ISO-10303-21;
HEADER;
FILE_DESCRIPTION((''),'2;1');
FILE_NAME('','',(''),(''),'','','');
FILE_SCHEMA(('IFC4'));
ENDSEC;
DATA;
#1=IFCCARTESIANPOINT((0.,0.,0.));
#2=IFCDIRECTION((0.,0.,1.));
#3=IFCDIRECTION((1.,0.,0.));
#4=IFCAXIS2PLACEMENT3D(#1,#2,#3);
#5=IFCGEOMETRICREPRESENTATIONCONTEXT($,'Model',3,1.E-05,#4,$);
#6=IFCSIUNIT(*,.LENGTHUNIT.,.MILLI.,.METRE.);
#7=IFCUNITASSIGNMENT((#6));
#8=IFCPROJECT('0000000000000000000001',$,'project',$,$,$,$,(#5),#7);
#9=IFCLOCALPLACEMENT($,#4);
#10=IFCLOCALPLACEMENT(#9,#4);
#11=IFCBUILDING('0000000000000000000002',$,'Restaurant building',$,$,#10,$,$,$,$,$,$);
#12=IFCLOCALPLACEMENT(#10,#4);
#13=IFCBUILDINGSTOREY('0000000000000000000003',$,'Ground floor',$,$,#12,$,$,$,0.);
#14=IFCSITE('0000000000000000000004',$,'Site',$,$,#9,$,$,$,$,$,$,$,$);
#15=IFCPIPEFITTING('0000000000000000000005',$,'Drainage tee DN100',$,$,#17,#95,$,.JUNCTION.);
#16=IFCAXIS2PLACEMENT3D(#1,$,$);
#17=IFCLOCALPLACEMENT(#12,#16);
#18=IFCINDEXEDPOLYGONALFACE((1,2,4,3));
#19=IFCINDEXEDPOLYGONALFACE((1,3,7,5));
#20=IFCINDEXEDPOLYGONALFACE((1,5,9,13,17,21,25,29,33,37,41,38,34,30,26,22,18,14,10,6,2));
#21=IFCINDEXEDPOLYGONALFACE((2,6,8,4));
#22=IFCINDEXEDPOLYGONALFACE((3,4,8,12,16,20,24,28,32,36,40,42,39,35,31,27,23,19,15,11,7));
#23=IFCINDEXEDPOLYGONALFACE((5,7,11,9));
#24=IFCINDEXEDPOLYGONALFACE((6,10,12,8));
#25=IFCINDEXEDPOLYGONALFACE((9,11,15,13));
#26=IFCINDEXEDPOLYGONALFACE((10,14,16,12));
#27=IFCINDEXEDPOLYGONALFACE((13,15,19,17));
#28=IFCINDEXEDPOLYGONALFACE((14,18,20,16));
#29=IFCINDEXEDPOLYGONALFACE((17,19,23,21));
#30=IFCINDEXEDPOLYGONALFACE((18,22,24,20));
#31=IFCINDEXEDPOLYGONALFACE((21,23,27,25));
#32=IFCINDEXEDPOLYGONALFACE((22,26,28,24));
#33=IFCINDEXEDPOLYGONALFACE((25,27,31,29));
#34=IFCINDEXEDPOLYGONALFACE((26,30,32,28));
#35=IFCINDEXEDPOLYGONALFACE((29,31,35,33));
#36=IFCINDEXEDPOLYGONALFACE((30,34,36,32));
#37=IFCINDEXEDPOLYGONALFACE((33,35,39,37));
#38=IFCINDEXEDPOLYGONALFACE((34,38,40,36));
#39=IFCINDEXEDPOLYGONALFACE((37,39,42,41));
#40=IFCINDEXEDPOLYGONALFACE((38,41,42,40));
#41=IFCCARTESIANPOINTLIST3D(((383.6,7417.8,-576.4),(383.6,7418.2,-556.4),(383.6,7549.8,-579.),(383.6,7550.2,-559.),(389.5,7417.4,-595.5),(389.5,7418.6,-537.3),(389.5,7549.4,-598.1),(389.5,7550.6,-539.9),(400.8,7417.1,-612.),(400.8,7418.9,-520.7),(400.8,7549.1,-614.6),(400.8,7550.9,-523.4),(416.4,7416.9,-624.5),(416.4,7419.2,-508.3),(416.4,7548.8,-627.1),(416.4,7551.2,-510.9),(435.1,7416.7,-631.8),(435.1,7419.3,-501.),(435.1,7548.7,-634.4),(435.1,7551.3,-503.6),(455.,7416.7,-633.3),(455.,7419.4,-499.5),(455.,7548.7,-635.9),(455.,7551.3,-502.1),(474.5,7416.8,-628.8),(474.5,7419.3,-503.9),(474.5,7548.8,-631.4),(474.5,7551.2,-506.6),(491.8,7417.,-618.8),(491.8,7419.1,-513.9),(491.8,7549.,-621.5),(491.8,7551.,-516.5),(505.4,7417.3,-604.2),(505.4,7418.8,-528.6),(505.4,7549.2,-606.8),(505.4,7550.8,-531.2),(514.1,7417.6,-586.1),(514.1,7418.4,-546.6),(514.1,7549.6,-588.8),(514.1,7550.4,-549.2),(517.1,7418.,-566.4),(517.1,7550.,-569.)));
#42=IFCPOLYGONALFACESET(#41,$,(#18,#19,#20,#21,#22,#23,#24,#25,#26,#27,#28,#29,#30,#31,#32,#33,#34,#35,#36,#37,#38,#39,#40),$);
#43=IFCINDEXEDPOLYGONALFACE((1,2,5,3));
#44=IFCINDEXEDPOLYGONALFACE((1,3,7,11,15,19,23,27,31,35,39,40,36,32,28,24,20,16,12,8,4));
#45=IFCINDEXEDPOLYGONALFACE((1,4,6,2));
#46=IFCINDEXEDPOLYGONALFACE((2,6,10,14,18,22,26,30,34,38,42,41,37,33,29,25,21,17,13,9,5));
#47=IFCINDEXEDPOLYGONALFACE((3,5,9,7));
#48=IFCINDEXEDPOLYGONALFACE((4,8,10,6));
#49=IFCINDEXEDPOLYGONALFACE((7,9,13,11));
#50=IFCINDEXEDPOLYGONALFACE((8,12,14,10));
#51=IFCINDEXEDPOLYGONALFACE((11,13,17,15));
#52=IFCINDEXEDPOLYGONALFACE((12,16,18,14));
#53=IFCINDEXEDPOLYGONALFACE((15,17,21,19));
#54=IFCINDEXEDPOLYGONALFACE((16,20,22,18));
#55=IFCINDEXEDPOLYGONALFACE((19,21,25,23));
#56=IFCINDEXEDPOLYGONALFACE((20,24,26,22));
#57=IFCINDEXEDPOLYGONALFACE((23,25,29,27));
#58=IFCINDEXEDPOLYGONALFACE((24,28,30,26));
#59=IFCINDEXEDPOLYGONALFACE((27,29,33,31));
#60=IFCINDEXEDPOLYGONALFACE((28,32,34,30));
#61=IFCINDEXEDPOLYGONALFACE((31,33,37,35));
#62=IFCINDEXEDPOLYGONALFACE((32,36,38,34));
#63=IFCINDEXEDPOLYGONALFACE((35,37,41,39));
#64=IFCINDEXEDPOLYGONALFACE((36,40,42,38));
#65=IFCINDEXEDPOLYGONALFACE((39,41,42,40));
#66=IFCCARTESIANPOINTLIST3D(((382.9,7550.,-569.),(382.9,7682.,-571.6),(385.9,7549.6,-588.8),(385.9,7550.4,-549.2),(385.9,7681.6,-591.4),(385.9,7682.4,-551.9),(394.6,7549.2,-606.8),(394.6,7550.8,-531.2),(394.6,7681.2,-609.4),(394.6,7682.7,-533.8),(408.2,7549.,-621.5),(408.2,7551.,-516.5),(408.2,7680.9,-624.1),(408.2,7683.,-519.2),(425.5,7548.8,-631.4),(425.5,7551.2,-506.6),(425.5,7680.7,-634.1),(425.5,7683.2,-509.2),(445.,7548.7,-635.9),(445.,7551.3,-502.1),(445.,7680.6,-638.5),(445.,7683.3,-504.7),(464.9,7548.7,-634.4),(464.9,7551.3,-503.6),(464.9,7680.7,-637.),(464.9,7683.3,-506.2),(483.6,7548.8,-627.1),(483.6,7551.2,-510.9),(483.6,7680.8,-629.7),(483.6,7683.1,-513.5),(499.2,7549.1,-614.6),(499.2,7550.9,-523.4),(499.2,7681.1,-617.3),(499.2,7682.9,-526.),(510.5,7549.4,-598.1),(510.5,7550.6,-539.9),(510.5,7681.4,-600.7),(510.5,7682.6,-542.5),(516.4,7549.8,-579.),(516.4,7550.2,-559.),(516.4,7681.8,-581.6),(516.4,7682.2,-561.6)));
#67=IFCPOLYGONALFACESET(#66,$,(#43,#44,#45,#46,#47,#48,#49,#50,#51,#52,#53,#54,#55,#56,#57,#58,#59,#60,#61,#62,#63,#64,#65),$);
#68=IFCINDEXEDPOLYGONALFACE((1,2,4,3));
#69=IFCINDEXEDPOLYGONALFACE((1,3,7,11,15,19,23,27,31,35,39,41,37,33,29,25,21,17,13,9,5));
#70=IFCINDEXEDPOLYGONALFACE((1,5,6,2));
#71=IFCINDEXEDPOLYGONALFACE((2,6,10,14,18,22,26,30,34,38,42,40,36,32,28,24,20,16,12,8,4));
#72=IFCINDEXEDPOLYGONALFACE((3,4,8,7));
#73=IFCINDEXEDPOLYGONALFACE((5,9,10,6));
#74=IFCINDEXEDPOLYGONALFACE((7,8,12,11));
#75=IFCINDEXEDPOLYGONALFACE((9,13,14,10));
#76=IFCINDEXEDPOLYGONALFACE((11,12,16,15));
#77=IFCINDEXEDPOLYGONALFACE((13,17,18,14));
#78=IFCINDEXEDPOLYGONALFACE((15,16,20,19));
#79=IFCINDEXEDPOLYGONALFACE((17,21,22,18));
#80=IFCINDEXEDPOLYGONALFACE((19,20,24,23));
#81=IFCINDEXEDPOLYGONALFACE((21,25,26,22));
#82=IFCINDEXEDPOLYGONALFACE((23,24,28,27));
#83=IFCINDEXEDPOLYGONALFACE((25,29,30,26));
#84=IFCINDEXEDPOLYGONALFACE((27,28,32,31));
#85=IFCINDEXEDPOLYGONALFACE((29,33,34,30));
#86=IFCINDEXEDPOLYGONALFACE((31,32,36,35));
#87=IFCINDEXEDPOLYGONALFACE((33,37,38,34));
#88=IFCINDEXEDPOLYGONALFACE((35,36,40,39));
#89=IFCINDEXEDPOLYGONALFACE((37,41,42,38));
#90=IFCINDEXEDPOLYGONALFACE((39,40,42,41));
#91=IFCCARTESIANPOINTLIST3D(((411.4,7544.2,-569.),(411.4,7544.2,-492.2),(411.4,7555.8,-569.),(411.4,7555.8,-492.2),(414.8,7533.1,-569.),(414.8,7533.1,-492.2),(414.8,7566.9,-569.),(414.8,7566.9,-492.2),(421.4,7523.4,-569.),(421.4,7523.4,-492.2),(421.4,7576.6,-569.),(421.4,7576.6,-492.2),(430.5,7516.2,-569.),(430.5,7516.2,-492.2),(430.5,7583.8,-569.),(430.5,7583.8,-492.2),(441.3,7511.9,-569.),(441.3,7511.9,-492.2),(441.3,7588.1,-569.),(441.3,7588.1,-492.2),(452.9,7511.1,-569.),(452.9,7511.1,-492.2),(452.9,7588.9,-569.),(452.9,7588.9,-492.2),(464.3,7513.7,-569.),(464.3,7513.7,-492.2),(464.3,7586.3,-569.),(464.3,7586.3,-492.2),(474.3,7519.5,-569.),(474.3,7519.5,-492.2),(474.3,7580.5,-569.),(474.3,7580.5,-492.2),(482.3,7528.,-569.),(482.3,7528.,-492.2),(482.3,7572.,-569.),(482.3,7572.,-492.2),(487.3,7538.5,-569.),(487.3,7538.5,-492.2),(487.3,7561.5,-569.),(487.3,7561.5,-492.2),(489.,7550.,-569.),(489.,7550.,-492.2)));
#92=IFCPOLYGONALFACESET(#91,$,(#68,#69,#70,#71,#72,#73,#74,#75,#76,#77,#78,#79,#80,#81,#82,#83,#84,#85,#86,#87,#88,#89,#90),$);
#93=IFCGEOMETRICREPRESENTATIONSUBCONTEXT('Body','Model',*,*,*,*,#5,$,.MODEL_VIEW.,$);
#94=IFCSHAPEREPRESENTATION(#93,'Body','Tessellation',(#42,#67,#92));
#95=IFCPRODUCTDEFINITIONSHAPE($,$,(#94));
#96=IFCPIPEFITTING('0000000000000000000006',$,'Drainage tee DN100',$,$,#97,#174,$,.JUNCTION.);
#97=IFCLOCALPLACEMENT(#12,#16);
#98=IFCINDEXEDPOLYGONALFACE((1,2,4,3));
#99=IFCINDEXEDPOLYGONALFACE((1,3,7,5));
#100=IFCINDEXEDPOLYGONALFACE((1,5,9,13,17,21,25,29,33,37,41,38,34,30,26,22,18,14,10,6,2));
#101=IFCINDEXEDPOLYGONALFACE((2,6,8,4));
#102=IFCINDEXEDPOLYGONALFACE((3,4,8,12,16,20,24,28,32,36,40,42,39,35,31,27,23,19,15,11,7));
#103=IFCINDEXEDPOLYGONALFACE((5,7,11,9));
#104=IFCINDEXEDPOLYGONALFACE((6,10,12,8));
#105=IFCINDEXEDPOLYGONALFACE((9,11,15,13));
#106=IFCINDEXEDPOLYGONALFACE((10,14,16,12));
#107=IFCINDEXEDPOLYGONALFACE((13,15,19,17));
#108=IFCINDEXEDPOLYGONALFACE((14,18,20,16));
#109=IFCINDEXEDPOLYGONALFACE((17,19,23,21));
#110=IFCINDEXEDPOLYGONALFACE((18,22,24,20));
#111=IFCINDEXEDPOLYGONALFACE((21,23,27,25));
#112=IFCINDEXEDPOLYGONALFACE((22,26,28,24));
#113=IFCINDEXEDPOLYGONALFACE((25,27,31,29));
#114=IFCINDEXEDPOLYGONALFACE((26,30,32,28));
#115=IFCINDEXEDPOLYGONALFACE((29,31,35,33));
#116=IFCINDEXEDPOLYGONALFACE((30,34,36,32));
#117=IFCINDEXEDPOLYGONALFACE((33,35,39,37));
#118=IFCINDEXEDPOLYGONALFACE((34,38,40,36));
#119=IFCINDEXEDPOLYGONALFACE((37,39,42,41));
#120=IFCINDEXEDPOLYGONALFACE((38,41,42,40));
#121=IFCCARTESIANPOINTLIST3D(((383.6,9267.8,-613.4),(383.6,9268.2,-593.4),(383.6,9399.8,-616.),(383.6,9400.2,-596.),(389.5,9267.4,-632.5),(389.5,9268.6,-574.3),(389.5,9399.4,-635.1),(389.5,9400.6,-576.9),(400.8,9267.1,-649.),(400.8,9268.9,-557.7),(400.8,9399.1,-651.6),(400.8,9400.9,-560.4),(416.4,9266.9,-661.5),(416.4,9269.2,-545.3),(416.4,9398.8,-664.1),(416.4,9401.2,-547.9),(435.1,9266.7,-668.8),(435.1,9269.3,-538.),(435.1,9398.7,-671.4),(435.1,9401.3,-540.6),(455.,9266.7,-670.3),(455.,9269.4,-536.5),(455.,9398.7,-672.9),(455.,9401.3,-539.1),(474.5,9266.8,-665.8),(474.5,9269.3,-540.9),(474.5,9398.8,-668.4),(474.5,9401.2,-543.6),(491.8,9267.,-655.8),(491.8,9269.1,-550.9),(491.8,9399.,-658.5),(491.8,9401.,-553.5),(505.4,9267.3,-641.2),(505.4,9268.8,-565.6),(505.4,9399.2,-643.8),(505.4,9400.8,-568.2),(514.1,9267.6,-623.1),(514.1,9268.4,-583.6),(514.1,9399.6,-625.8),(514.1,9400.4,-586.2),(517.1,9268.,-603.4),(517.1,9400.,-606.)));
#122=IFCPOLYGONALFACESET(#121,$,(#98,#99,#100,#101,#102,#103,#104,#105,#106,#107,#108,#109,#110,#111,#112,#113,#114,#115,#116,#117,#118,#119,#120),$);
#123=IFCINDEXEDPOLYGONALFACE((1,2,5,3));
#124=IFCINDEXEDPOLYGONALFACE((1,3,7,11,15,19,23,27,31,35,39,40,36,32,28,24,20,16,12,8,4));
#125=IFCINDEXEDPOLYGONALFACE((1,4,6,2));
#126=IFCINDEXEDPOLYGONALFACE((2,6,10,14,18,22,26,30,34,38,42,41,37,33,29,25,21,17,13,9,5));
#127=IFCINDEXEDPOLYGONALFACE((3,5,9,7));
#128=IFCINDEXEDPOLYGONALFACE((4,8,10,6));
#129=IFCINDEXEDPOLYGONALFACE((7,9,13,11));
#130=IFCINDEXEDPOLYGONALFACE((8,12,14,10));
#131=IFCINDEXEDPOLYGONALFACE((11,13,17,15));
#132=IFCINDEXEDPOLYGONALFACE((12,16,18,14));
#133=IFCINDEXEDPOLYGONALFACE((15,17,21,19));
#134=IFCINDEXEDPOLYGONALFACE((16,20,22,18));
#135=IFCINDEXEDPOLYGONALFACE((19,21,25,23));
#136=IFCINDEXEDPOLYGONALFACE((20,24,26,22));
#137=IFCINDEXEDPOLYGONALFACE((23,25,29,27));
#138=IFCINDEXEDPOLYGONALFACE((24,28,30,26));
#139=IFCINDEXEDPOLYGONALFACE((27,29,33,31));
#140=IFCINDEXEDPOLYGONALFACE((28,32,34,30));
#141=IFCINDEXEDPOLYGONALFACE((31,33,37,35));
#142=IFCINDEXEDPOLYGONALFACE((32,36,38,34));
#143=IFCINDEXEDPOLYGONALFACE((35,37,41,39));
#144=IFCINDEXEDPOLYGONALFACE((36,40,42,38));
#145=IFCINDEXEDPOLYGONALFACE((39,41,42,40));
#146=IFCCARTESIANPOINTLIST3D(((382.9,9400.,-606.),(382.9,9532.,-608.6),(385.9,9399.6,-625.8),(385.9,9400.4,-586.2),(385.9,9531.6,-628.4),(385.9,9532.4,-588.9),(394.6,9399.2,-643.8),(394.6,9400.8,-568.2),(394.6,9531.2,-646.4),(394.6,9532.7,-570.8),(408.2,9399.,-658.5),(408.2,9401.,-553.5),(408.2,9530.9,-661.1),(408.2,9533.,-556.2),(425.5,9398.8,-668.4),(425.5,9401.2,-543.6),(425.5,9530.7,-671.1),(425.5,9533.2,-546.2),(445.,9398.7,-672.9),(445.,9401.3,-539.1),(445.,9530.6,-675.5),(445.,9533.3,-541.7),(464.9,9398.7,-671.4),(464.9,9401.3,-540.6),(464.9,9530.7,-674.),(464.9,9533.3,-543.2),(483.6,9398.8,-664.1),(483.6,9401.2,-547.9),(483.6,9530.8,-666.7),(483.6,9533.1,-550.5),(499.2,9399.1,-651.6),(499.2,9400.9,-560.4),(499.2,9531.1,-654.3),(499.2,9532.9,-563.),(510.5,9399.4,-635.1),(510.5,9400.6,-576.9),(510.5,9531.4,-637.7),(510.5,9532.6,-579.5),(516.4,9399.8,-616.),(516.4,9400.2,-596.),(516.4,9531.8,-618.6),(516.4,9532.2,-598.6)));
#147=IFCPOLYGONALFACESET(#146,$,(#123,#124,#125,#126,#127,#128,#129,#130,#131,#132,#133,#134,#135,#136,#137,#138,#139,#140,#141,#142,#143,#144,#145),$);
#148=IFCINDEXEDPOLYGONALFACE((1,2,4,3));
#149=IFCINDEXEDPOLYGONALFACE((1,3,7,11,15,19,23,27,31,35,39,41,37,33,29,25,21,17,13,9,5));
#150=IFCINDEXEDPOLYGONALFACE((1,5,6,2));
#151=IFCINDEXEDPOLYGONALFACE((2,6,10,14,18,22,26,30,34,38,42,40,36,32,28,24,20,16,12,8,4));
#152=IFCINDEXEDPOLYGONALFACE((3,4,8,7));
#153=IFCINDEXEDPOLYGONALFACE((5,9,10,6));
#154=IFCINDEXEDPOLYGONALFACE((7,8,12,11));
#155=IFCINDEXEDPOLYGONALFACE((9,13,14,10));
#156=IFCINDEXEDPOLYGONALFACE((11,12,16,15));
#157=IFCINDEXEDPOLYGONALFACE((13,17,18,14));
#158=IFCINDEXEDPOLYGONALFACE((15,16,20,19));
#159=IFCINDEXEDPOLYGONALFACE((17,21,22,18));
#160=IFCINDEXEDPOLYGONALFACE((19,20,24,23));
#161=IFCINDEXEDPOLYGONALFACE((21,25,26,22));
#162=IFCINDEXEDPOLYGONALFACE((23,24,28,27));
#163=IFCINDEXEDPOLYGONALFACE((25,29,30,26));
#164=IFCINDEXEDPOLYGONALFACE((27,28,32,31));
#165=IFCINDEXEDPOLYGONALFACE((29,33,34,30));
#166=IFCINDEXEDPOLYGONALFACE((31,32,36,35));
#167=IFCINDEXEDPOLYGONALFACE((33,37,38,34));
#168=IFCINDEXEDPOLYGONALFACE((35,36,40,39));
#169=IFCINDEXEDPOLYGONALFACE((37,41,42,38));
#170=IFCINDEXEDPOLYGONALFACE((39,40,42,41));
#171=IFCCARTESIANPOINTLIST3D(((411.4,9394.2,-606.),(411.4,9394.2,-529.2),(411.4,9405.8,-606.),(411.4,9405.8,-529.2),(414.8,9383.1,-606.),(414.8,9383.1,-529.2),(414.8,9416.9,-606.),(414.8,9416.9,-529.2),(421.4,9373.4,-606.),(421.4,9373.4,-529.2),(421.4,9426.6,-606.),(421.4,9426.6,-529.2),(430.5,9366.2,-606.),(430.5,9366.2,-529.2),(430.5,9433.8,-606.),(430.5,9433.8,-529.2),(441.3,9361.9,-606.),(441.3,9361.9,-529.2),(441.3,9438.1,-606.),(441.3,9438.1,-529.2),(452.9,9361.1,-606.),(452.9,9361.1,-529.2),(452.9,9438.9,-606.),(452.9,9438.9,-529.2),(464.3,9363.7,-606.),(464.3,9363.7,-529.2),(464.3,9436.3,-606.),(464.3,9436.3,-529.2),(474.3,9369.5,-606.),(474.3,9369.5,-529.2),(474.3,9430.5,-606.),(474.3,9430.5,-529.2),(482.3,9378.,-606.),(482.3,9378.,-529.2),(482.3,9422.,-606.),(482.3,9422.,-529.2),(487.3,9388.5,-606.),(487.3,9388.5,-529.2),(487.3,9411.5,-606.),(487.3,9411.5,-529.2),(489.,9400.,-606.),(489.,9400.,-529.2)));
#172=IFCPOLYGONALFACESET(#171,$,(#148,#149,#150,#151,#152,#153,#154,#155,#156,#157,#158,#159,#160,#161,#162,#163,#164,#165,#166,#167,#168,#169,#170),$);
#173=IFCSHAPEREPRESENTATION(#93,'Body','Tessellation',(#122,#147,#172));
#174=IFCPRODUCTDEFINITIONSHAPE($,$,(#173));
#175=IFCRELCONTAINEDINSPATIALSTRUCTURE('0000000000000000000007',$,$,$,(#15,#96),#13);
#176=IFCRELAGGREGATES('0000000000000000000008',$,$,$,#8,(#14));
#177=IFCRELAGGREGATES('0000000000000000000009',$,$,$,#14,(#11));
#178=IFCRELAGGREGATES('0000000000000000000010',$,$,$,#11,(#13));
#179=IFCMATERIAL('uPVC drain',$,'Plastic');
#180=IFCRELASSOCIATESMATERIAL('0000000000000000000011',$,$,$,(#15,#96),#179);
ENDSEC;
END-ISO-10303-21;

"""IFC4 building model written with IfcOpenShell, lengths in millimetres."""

from ifc_helpers import new_model, si_unit, frame, origin, origin_with_axes, origin_2d, place, context, subcontext, project, spatial, circle, extrude, material, element, save


model = new_model("IFC4")

# Units and contexts
model_context = context("Model", 3, precision=1e-05, world=origin_with_axes())
body_context = subcontext(model_context, "Body", "Model", "MODEL_VIEW")
ifc_project = project(units=[si_unit("LENGTHUNIT", "METRE", prefix="MILLI")], contexts=[model_context])

# Site, building, storey
site_placement = place(None, origin_with_axes())
site = spatial("IfcSite", under=ifc_project, at=site_placement, Name="Site")
building_placement = place(site_placement, origin_with_axes())
building = spatial("IfcBuilding", under=site, at=building_placement, Name="Restaurant building")
storey_placement = place(building_placement, origin_with_axes())
storey = spatial("IfcBuildingStorey", under=building, at=storey_placement, Name="Ground floor", Elevation=0.0)

# Shared definitions
ifc_material_1 = material(Name="uPVC drain", Category="Plastic")

# Pipe fittings
for number, where, name in (
    (1, (450.0, 7550.0, -569.0), "Drainage tee DN100"),
    (2, (450.0, 9400.0, -606.0), "Drainage tee DN100"),
):
    element("IfcPipeFitting", number, at=place(storey_placement, frame(where)), inside=storey, material=ifc_material_1, Name=name, PredefinedType="JUNCTION", context=body_context, shape_type="SweptSolid", body=[
        extrude(circle(Radius=67.1, at=origin_2d()), frame((0.0, 0.0, 0.0), z_axis=(0.0, -0.9998, 0.019996), x_axis=(1.0, 0.0, 0.0)), (0.0, 0.0, 1.0), 132.0),
        extrude(circle(Radius=67.1, at=origin_2d()), frame((0.0, 0.0, 0.0), z_axis=(0.0, 0.9998, -0.019996), x_axis=(-1.0, 0.0, 0.0)), (0.0, 0.0, 1.0), 132.0),
        extrude(circle(Radius=39.0, at=origin_2d()), origin(), (0.0, 0.0, 1.0), 76.8),
    ])

save(model, "model.ifc")
